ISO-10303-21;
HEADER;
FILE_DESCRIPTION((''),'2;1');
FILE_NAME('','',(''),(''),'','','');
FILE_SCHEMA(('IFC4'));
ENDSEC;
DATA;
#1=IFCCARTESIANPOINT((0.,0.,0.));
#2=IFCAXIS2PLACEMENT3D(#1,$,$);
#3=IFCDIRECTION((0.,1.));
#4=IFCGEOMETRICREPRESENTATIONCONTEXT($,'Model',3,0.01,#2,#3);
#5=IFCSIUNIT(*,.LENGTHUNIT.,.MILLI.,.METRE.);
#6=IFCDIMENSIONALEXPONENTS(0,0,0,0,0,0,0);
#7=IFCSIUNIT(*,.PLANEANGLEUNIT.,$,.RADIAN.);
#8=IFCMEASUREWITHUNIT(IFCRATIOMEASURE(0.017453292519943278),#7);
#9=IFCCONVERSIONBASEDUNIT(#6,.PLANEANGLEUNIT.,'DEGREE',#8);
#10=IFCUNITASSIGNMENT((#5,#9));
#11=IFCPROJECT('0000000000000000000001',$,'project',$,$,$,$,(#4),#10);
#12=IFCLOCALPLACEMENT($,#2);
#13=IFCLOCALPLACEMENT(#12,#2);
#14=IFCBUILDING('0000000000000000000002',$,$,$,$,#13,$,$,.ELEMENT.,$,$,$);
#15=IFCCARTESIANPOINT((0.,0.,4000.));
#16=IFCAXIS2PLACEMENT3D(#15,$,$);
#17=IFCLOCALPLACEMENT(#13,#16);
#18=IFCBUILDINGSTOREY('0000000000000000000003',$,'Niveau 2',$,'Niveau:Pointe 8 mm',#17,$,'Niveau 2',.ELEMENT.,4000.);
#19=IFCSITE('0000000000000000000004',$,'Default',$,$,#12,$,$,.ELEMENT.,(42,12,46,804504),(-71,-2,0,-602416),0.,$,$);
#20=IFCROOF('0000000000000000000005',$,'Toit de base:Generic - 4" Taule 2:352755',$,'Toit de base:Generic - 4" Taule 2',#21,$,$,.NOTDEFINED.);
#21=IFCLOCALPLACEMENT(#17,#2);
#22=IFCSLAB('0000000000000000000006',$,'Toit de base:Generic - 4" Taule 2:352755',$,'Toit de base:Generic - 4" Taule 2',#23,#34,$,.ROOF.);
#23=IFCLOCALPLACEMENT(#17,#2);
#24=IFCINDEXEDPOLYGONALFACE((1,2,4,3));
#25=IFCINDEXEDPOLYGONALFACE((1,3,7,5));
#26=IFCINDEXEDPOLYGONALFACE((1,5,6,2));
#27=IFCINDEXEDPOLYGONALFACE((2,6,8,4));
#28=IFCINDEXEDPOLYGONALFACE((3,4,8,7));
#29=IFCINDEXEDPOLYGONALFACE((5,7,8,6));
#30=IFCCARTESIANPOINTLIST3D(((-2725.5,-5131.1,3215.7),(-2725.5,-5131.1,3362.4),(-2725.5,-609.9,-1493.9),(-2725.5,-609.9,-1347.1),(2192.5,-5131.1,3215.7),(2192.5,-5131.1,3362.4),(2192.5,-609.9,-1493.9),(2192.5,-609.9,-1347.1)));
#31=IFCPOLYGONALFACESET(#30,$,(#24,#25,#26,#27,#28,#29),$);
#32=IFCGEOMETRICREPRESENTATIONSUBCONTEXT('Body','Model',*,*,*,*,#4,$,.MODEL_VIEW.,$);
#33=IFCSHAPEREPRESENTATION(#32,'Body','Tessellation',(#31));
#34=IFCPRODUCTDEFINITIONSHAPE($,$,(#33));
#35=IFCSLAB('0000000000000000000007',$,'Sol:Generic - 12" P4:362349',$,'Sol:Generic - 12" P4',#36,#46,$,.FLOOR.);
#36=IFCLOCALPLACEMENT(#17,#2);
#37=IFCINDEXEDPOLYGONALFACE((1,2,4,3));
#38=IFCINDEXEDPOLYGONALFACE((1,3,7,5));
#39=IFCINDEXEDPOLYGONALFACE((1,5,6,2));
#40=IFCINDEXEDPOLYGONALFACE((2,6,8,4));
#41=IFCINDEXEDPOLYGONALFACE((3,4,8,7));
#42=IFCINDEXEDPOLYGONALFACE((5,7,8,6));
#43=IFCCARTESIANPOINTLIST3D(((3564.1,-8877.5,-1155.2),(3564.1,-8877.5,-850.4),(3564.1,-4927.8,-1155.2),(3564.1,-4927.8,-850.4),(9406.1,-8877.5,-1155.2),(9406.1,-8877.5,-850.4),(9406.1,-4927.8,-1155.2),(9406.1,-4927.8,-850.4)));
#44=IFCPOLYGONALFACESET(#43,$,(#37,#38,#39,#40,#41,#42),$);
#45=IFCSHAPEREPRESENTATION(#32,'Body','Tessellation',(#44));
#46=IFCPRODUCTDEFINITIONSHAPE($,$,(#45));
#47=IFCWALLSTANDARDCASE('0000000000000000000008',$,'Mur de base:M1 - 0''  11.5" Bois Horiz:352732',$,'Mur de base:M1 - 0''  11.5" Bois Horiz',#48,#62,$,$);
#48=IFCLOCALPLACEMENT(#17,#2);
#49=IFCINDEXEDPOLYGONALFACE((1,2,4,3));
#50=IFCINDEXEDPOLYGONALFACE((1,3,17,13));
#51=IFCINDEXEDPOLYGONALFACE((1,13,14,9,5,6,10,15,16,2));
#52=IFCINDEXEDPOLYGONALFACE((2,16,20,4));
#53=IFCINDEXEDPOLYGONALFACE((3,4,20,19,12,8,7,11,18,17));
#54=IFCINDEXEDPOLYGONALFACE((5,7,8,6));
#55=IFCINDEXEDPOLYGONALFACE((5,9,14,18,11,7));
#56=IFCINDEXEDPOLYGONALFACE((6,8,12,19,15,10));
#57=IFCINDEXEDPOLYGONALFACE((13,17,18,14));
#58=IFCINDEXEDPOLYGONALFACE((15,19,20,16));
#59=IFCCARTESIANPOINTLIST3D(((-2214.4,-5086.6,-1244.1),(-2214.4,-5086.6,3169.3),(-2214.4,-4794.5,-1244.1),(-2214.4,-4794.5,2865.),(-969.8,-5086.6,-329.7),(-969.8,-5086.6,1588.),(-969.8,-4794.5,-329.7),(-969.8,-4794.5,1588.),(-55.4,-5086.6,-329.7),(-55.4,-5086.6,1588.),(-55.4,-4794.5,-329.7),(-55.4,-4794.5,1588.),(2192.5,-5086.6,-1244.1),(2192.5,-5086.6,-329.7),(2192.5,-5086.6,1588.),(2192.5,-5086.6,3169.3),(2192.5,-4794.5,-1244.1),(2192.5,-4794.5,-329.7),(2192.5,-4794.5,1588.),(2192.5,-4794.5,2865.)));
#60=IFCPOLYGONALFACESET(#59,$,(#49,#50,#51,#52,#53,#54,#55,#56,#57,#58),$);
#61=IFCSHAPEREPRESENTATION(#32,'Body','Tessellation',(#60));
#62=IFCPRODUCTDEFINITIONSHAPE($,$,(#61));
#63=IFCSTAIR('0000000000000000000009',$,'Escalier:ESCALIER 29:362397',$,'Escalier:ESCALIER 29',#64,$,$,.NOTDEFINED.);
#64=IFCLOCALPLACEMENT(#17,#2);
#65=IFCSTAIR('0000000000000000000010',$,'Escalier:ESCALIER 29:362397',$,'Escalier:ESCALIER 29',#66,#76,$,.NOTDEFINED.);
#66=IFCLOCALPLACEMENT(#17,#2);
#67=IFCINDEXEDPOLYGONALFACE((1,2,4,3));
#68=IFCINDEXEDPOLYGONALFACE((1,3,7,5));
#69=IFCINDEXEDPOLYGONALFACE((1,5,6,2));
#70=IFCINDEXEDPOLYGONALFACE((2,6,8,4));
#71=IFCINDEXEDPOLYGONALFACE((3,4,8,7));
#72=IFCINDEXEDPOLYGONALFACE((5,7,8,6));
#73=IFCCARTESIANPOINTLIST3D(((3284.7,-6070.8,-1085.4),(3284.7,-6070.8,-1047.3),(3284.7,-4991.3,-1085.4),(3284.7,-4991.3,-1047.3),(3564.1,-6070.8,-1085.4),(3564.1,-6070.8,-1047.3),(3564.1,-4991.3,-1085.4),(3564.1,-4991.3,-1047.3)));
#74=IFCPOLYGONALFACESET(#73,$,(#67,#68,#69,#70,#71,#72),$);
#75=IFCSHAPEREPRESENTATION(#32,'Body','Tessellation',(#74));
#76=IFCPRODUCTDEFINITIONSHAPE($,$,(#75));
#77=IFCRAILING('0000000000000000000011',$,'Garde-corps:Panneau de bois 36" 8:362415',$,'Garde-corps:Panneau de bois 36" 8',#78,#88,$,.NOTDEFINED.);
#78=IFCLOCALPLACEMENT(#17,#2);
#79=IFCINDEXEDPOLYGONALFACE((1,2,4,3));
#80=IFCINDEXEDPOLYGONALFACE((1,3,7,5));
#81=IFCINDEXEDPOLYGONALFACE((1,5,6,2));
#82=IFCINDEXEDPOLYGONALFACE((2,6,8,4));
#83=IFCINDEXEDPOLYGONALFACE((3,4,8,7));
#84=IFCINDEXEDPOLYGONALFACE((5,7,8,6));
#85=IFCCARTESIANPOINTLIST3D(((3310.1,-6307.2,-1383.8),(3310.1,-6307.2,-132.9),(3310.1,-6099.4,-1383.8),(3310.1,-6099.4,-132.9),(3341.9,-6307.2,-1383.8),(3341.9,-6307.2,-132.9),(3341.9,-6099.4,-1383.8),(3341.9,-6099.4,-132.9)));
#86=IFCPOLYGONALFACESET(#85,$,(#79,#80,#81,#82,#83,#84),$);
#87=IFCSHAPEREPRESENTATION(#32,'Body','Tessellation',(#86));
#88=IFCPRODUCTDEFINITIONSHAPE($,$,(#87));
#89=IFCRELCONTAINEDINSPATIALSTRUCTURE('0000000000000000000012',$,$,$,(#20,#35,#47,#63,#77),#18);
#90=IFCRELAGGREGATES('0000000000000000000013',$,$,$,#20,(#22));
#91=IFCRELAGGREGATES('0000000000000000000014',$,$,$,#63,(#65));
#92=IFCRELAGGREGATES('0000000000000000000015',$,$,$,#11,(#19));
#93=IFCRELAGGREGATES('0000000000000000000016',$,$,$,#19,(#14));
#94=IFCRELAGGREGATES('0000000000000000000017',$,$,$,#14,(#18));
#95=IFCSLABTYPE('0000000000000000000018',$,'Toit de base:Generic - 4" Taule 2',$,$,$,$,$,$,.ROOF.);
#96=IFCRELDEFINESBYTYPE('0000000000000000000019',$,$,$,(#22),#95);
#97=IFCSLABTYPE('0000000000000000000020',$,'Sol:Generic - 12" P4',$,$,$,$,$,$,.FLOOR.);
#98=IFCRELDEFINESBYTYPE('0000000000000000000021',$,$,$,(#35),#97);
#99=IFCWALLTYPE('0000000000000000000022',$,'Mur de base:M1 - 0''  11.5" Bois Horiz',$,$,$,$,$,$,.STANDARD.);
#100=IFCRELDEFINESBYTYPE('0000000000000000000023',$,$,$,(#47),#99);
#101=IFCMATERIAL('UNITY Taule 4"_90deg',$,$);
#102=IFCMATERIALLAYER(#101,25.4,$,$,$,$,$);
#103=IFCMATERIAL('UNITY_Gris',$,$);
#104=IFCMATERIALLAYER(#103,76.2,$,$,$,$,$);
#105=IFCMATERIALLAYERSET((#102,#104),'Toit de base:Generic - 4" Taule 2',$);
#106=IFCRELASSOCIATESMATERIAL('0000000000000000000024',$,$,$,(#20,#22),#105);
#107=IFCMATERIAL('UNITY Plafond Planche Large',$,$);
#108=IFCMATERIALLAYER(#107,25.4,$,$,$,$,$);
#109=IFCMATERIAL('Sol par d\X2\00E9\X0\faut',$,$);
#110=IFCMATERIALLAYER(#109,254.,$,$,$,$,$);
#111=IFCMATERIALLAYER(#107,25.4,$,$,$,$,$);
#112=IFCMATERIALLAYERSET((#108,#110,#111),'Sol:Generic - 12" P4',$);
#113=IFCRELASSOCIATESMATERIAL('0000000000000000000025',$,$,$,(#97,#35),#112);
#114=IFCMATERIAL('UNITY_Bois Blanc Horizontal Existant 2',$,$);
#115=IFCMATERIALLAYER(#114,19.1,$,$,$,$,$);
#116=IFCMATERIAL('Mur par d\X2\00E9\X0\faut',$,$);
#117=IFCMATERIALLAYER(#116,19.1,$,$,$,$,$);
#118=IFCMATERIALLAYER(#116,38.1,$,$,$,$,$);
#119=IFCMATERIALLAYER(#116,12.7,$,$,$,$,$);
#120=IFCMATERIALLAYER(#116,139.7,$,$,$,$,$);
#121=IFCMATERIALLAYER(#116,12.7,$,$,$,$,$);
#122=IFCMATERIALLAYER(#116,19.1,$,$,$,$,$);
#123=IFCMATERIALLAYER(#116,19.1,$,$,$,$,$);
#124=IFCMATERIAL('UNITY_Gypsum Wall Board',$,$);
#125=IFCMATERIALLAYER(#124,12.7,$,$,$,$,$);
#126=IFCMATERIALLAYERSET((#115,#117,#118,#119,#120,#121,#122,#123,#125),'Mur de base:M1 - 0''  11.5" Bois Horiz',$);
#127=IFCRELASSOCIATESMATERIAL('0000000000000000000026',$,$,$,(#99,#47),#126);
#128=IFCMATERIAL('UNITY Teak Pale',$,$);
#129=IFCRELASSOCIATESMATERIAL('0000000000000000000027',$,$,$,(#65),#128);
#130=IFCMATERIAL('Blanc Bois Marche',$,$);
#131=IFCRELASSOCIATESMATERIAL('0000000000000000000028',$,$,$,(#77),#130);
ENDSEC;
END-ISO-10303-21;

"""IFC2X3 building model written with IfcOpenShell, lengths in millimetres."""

from ifc_helpers import new_model, entity, si_unit, converted_unit, direction, frame, frame_2d, origin, origin_2d_with_axis, place, context, subcontext, project, spatial, polyline, rectangle, extrude, clip, bounded_halfspace, material, layer, layer_set, layer_usage, type_object, element, aggregate, save


model = new_model("IFC2X3")

# Units and contexts
model_context = context("Model", 3, precision=0.01, world=origin(), true_north=direction((0.0, 1.0)))
body_context = subcontext(model_context, "Body", "Model", "MODEL_VIEW")
ifc_project = project(units=[si_unit("LENGTHUNIT", "METRE", prefix="MILLI"), converted_unit("PLANEANGLEUNIT", "DEGREE", entity("IfcRatioMeasure", 0.017453292519943278), si_unit("PLANEANGLEUNIT", "RADIAN"), dimensions=[0, 0, 0, 0, 0, 0, 0])], contexts=[model_context])

# Site, building, storey
site_placement = place(None, origin())
site = spatial("IfcSite", under=ifc_project, at=site_placement, Name="Default", CompositionType="ELEMENT", RefLatitude=(42, 12, 46, 804504), RefLongitude=(-71, -2, 0, -602416), RefElevation=0.0)
building_placement = place(site_placement, origin())
building = spatial("IfcBuilding", under=site, at=building_placement, CompositionType="ELEMENT")
storey_placement = place(building_placement, frame((0.0, 0.0, 4000.0)))
storey = spatial("IfcBuildingStorey", under=building, at=storey_placement, Name="Niveau 2", ObjectType="Niveau:Pointe 8 mm", LongName="Niveau 2", CompositionType="ELEMENT", Elevation=4000.0)

# Roof, slab
ifc_material_1 = material(Name="UNITY Taule 4\"_90deg")
ifc_layer_1 = layer(ifc_material_1, 25.4)
ifc_material_2 = material(Name="UNITY_Gris")
ifc_layer_2 = layer(ifc_material_2, 76.2)
ifc_layer_set_1 = layer_set([ifc_layer_1, ifc_layer_2], Name="Toit de base:Generic - 4\" Taule 2")
roof_1_placement = place(storey_placement, frame((-2725.5, -5131.1, -1493.9)))
roof_1 = element("IfcRoof", 1, at=roof_1_placement, inside=storey, material=ifc_layer_set_1, Name="Toit de base:Generic - 4\" Taule 2:352755", ObjectType="Toit de base:Generic - 4\" Taule 2", ShapeType="NOTDEFINED")
slab_type_1 = type_object("IfcSlabType", Name="Toit de base:Generic - 4\" Taule 2", PredefinedType="ROOF")
slab_1_placement = place(roof_1_placement, origin())
slab_1 = element("IfcSlab", 2, at=slab_1_placement, type_object=slab_type_1, material=ifc_layer_set_1, Name="Toit de base:Generic - 4\" Taule 2:352755", ObjectType="Toit de base:Generic - 4\" Taule 2", PredefinedType="ROOF", context=body_context, shape_type="SweptSolid", body=[
    extrude(rectangle(XDim=4918.1, YDim=6528.5, at=frame_2d((0.0, 0.0), x_axis=(-1.0, 0.0))), frame((2459.0, 2260.6, 2354.8), z_axis=(0.0, 0.721387, 0.692532), x_axis=(1.0, 0.0, 0.0)), (0.0, -0.721387, 0.692532), 146.7),
])
aggregate(roof_1, [slab_1])

# Slab
ifc_material_3 = material(Name="UNITY Plafond Planche Large")
ifc_layer_3 = layer(ifc_material_3, 25.4)
ifc_material_4 = material(Name="Sol par défaut")
ifc_layer_4 = layer(ifc_material_4, 254.0)
ifc_layer_5 = layer(ifc_material_3, 25.4)
ifc_layer_set_2 = layer_set([ifc_layer_3, ifc_layer_4, ifc_layer_5], Name="Sol:Generic - 12\" P4")
ifc_layer_usage_1 = layer_usage(ifc_layer_set_2, "AXIS3", "POSITIVE", 0.0)
slab_type_2 = type_object("IfcSlabType", Name="Sol:Generic - 12\" P4", PredefinedType="FLOOR", material=ifc_layer_set_2)
slab_2_placement = place(storey_placement, origin())
element("IfcSlab", 3, at=slab_2_placement, inside=storey, type_object=slab_type_2, material=ifc_layer_usage_1, Name="Sol:Generic - 12\" P4:362349", ObjectType="Sol:Generic - 12\" P4", PredefinedType="FLOOR", context=body_context, shape_type="SweptSolid", body=[
    extrude(rectangle(XDim=3949.7, YDim=5842.0, at=origin_2d_with_axis()), frame((6485.1, -6902.7, -850.4), z_axis=(0.0, 0.0, -1.0), x_axis=(0.0, 1.0, 0.0)), (0.0, 0.0, 1.0), 304.8),
])

# Wall, openings
ifc_material_5 = material(Name="UNITY_Bois Blanc Horizontal Existant 2")
ifc_layer_6 = layer(ifc_material_5, 19.1)
ifc_material_6 = material(Name="Mur par défaut")
ifc_layer_7 = layer(ifc_material_6, 19.1)
ifc_layer_8 = layer(ifc_material_6, 38.1)
ifc_layer_9 = layer(ifc_material_6, 12.7)
ifc_layer_10 = layer(ifc_material_6, 139.7)
ifc_layer_11 = layer(ifc_material_6, 12.7)
ifc_layer_12 = layer(ifc_material_6, 19.1)
ifc_layer_13 = layer(ifc_material_6, 19.1)
ifc_material_7 = material(Name="UNITY_Gypsum Wall Board")
ifc_layer_14 = layer(ifc_material_7, 12.7)
ifc_layer_set_3 = layer_set([ifc_layer_6, ifc_layer_7, ifc_layer_8, ifc_layer_9, ifc_layer_10, ifc_layer_11, ifc_layer_12, ifc_layer_13, ifc_layer_14], Name="Mur de base:M1 - 0'  11.5\" Bois Horiz")
ifc_layer_usage_2 = layer_usage(ifc_layer_set_3, "AXIS2", "NEGATIVE", 146.1)
wall_type = type_object("IfcWallType", Name="Mur de base:M1 - 0'  11.5\" Bois Horiz", PredefinedType="STANDARD", material=ifc_layer_set_3)
wall_1_placement = place(storey_placement, frame((2192.5, -4940.5, -1244.1), z_axis=(0.0, 0.0, 1.0), x_axis=(-1.0, 0.0, 0.0)))
wall_1 = element("IfcWallStandardCase", 4, at=wall_1_placement, inside=storey, type_object=wall_type, material=ifc_layer_usage_2, Name="Mur de base:M1 - 0'  11.5\" Bois Horiz:352732", ObjectType="Mur de base:M1 - 0'  11.5\" Bois Horiz", context=body_context, shape_type="Clipping", body=[
    clip(extrude(rectangle(XDim=4406.9, YDim=292.1, at=frame_2d((2203.5, 0.0), x_axis=(-1.0, 0.0))), origin(), (0.0, 0.0, 1.0), 4413.4), bounded_halfspace(frame((0.0, -146.0, 4109.1), z_axis=(0.0, -0.721387, 0.692532), x_axis=(1.0, 0.0, 0.0)), False, frame((0.0, -146.0, 4109.1)), polyline([(0.0, 0.0), (4114.8, 0.0), (4406.9, 0.0), (4406.9, 292.1), (0.0, 292.1), (0.0, 0.0)]))),
])
opening_1_placement = place(wall_1_placement, frame((2192.5, -4940.5, 1244.1), z_axis=(0.0, 0.0, 1.0), x_axis=(-1.0, 0.0, 0.0)))
element("IfcOpeningElement", 5, at=opening_1_placement, cuts=wall_1, ObjectType="Opening", context=body_context, shape_type="SweptSolid", body=[
    extrude(rectangle(XDim=1917.7, YDim=2254.3, at=frame_2d((0.0, 0.0), x_axis=(1.0, 0.0))), frame((1071.7, -3270.5, 629.1), z_axis=(0.0, -1.0, 0.0), x_axis=(0.0, 0.0, 1.0)), (0.0, 0.0, 1.0), 3048.0),
])
opening_2_placement = place(wall_1_placement, frame((2192.5, -4940.5, 1244.1), z_axis=(0.0, 0.0, 1.0), x_axis=(-1.0, 0.0, 0.0)))
element("IfcOpeningElement", 6, at=opening_2_placement, cuts=wall_1, ObjectType="Opening", context=body_context, shape_type="SweptSolid", body=[
    extrude(rectangle(XDim=1917.7, YDim=914.4, at=frame_2d((0.0, 0.0), x_axis=(1.0, 0.0))), frame((-512.6, -3270.5, 629.1), z_axis=(0.0, -1.0, 0.0), x_axis=(0.0, 0.0, 1.0)), (0.0, 0.0, 1.0), 3048.0),
])

# Stairs
stair_1_placement = place(storey_placement, origin())
stair_1 = element("IfcStair", 7, at=stair_1_placement, inside=storey, Name="Escalier:ESCALIER 29:362397", ObjectType="Escalier:ESCALIER 29", ShapeType="NOTDEFINED")
ifc_material_8 = material(Name="UNITY Teak Pale")
stair_2_placement = place(stair_1_placement, origin())
stair_2 = element("IfcStair", 8, at=stair_2_placement, material=ifc_material_8, Name="Escalier:ESCALIER 29:362397", ObjectType="Escalier:ESCALIER 29", ShapeType="NOTDEFINED", context=body_context, shape_type="SweptSolid", body=[
    extrude(rectangle(XDim=279.4, YDim=1079.5, at=frame_2d((0.0, 0.0), x_axis=(1.0, 0.0))), frame((3424.4, -5531.1, -1085.4), z_axis=(0.0, 0.0, 1.0), x_axis=(-1.0, 0.0, 0.0)), (0.0, 0.0, 1.0), 38.1),
])

# Railing
ifc_material_9 = material(Name="Blanc Bois Marche")
aggregate(stair_1, [stair_2])
railing_1_placement = place(storey_placement, origin())
element("IfcRailing", 9, at=railing_1_placement, inside=storey, material=ifc_material_9, Name="Garde-corps:Panneau de bois 36\" 8:362415", ObjectType="Garde-corps:Panneau de bois 36\" 8", PredefinedType="NOTDEFINED", context=body_context, shape_type="SweptSolid", body=[
    extrude(rectangle(XDim=207.8, YDim=31.7, at=frame_2d((0.0, 0.0), x_axis=(1.0, 0.0))), frame((3326.0, -6203.3, -1383.8), z_axis=(0.0, 0.0, 1.0), x_axis=(0.0, 1.0, 0.0)), (0.0, 0.0, 1.0), 1250.9),
])

save(model, "model.ifc")
